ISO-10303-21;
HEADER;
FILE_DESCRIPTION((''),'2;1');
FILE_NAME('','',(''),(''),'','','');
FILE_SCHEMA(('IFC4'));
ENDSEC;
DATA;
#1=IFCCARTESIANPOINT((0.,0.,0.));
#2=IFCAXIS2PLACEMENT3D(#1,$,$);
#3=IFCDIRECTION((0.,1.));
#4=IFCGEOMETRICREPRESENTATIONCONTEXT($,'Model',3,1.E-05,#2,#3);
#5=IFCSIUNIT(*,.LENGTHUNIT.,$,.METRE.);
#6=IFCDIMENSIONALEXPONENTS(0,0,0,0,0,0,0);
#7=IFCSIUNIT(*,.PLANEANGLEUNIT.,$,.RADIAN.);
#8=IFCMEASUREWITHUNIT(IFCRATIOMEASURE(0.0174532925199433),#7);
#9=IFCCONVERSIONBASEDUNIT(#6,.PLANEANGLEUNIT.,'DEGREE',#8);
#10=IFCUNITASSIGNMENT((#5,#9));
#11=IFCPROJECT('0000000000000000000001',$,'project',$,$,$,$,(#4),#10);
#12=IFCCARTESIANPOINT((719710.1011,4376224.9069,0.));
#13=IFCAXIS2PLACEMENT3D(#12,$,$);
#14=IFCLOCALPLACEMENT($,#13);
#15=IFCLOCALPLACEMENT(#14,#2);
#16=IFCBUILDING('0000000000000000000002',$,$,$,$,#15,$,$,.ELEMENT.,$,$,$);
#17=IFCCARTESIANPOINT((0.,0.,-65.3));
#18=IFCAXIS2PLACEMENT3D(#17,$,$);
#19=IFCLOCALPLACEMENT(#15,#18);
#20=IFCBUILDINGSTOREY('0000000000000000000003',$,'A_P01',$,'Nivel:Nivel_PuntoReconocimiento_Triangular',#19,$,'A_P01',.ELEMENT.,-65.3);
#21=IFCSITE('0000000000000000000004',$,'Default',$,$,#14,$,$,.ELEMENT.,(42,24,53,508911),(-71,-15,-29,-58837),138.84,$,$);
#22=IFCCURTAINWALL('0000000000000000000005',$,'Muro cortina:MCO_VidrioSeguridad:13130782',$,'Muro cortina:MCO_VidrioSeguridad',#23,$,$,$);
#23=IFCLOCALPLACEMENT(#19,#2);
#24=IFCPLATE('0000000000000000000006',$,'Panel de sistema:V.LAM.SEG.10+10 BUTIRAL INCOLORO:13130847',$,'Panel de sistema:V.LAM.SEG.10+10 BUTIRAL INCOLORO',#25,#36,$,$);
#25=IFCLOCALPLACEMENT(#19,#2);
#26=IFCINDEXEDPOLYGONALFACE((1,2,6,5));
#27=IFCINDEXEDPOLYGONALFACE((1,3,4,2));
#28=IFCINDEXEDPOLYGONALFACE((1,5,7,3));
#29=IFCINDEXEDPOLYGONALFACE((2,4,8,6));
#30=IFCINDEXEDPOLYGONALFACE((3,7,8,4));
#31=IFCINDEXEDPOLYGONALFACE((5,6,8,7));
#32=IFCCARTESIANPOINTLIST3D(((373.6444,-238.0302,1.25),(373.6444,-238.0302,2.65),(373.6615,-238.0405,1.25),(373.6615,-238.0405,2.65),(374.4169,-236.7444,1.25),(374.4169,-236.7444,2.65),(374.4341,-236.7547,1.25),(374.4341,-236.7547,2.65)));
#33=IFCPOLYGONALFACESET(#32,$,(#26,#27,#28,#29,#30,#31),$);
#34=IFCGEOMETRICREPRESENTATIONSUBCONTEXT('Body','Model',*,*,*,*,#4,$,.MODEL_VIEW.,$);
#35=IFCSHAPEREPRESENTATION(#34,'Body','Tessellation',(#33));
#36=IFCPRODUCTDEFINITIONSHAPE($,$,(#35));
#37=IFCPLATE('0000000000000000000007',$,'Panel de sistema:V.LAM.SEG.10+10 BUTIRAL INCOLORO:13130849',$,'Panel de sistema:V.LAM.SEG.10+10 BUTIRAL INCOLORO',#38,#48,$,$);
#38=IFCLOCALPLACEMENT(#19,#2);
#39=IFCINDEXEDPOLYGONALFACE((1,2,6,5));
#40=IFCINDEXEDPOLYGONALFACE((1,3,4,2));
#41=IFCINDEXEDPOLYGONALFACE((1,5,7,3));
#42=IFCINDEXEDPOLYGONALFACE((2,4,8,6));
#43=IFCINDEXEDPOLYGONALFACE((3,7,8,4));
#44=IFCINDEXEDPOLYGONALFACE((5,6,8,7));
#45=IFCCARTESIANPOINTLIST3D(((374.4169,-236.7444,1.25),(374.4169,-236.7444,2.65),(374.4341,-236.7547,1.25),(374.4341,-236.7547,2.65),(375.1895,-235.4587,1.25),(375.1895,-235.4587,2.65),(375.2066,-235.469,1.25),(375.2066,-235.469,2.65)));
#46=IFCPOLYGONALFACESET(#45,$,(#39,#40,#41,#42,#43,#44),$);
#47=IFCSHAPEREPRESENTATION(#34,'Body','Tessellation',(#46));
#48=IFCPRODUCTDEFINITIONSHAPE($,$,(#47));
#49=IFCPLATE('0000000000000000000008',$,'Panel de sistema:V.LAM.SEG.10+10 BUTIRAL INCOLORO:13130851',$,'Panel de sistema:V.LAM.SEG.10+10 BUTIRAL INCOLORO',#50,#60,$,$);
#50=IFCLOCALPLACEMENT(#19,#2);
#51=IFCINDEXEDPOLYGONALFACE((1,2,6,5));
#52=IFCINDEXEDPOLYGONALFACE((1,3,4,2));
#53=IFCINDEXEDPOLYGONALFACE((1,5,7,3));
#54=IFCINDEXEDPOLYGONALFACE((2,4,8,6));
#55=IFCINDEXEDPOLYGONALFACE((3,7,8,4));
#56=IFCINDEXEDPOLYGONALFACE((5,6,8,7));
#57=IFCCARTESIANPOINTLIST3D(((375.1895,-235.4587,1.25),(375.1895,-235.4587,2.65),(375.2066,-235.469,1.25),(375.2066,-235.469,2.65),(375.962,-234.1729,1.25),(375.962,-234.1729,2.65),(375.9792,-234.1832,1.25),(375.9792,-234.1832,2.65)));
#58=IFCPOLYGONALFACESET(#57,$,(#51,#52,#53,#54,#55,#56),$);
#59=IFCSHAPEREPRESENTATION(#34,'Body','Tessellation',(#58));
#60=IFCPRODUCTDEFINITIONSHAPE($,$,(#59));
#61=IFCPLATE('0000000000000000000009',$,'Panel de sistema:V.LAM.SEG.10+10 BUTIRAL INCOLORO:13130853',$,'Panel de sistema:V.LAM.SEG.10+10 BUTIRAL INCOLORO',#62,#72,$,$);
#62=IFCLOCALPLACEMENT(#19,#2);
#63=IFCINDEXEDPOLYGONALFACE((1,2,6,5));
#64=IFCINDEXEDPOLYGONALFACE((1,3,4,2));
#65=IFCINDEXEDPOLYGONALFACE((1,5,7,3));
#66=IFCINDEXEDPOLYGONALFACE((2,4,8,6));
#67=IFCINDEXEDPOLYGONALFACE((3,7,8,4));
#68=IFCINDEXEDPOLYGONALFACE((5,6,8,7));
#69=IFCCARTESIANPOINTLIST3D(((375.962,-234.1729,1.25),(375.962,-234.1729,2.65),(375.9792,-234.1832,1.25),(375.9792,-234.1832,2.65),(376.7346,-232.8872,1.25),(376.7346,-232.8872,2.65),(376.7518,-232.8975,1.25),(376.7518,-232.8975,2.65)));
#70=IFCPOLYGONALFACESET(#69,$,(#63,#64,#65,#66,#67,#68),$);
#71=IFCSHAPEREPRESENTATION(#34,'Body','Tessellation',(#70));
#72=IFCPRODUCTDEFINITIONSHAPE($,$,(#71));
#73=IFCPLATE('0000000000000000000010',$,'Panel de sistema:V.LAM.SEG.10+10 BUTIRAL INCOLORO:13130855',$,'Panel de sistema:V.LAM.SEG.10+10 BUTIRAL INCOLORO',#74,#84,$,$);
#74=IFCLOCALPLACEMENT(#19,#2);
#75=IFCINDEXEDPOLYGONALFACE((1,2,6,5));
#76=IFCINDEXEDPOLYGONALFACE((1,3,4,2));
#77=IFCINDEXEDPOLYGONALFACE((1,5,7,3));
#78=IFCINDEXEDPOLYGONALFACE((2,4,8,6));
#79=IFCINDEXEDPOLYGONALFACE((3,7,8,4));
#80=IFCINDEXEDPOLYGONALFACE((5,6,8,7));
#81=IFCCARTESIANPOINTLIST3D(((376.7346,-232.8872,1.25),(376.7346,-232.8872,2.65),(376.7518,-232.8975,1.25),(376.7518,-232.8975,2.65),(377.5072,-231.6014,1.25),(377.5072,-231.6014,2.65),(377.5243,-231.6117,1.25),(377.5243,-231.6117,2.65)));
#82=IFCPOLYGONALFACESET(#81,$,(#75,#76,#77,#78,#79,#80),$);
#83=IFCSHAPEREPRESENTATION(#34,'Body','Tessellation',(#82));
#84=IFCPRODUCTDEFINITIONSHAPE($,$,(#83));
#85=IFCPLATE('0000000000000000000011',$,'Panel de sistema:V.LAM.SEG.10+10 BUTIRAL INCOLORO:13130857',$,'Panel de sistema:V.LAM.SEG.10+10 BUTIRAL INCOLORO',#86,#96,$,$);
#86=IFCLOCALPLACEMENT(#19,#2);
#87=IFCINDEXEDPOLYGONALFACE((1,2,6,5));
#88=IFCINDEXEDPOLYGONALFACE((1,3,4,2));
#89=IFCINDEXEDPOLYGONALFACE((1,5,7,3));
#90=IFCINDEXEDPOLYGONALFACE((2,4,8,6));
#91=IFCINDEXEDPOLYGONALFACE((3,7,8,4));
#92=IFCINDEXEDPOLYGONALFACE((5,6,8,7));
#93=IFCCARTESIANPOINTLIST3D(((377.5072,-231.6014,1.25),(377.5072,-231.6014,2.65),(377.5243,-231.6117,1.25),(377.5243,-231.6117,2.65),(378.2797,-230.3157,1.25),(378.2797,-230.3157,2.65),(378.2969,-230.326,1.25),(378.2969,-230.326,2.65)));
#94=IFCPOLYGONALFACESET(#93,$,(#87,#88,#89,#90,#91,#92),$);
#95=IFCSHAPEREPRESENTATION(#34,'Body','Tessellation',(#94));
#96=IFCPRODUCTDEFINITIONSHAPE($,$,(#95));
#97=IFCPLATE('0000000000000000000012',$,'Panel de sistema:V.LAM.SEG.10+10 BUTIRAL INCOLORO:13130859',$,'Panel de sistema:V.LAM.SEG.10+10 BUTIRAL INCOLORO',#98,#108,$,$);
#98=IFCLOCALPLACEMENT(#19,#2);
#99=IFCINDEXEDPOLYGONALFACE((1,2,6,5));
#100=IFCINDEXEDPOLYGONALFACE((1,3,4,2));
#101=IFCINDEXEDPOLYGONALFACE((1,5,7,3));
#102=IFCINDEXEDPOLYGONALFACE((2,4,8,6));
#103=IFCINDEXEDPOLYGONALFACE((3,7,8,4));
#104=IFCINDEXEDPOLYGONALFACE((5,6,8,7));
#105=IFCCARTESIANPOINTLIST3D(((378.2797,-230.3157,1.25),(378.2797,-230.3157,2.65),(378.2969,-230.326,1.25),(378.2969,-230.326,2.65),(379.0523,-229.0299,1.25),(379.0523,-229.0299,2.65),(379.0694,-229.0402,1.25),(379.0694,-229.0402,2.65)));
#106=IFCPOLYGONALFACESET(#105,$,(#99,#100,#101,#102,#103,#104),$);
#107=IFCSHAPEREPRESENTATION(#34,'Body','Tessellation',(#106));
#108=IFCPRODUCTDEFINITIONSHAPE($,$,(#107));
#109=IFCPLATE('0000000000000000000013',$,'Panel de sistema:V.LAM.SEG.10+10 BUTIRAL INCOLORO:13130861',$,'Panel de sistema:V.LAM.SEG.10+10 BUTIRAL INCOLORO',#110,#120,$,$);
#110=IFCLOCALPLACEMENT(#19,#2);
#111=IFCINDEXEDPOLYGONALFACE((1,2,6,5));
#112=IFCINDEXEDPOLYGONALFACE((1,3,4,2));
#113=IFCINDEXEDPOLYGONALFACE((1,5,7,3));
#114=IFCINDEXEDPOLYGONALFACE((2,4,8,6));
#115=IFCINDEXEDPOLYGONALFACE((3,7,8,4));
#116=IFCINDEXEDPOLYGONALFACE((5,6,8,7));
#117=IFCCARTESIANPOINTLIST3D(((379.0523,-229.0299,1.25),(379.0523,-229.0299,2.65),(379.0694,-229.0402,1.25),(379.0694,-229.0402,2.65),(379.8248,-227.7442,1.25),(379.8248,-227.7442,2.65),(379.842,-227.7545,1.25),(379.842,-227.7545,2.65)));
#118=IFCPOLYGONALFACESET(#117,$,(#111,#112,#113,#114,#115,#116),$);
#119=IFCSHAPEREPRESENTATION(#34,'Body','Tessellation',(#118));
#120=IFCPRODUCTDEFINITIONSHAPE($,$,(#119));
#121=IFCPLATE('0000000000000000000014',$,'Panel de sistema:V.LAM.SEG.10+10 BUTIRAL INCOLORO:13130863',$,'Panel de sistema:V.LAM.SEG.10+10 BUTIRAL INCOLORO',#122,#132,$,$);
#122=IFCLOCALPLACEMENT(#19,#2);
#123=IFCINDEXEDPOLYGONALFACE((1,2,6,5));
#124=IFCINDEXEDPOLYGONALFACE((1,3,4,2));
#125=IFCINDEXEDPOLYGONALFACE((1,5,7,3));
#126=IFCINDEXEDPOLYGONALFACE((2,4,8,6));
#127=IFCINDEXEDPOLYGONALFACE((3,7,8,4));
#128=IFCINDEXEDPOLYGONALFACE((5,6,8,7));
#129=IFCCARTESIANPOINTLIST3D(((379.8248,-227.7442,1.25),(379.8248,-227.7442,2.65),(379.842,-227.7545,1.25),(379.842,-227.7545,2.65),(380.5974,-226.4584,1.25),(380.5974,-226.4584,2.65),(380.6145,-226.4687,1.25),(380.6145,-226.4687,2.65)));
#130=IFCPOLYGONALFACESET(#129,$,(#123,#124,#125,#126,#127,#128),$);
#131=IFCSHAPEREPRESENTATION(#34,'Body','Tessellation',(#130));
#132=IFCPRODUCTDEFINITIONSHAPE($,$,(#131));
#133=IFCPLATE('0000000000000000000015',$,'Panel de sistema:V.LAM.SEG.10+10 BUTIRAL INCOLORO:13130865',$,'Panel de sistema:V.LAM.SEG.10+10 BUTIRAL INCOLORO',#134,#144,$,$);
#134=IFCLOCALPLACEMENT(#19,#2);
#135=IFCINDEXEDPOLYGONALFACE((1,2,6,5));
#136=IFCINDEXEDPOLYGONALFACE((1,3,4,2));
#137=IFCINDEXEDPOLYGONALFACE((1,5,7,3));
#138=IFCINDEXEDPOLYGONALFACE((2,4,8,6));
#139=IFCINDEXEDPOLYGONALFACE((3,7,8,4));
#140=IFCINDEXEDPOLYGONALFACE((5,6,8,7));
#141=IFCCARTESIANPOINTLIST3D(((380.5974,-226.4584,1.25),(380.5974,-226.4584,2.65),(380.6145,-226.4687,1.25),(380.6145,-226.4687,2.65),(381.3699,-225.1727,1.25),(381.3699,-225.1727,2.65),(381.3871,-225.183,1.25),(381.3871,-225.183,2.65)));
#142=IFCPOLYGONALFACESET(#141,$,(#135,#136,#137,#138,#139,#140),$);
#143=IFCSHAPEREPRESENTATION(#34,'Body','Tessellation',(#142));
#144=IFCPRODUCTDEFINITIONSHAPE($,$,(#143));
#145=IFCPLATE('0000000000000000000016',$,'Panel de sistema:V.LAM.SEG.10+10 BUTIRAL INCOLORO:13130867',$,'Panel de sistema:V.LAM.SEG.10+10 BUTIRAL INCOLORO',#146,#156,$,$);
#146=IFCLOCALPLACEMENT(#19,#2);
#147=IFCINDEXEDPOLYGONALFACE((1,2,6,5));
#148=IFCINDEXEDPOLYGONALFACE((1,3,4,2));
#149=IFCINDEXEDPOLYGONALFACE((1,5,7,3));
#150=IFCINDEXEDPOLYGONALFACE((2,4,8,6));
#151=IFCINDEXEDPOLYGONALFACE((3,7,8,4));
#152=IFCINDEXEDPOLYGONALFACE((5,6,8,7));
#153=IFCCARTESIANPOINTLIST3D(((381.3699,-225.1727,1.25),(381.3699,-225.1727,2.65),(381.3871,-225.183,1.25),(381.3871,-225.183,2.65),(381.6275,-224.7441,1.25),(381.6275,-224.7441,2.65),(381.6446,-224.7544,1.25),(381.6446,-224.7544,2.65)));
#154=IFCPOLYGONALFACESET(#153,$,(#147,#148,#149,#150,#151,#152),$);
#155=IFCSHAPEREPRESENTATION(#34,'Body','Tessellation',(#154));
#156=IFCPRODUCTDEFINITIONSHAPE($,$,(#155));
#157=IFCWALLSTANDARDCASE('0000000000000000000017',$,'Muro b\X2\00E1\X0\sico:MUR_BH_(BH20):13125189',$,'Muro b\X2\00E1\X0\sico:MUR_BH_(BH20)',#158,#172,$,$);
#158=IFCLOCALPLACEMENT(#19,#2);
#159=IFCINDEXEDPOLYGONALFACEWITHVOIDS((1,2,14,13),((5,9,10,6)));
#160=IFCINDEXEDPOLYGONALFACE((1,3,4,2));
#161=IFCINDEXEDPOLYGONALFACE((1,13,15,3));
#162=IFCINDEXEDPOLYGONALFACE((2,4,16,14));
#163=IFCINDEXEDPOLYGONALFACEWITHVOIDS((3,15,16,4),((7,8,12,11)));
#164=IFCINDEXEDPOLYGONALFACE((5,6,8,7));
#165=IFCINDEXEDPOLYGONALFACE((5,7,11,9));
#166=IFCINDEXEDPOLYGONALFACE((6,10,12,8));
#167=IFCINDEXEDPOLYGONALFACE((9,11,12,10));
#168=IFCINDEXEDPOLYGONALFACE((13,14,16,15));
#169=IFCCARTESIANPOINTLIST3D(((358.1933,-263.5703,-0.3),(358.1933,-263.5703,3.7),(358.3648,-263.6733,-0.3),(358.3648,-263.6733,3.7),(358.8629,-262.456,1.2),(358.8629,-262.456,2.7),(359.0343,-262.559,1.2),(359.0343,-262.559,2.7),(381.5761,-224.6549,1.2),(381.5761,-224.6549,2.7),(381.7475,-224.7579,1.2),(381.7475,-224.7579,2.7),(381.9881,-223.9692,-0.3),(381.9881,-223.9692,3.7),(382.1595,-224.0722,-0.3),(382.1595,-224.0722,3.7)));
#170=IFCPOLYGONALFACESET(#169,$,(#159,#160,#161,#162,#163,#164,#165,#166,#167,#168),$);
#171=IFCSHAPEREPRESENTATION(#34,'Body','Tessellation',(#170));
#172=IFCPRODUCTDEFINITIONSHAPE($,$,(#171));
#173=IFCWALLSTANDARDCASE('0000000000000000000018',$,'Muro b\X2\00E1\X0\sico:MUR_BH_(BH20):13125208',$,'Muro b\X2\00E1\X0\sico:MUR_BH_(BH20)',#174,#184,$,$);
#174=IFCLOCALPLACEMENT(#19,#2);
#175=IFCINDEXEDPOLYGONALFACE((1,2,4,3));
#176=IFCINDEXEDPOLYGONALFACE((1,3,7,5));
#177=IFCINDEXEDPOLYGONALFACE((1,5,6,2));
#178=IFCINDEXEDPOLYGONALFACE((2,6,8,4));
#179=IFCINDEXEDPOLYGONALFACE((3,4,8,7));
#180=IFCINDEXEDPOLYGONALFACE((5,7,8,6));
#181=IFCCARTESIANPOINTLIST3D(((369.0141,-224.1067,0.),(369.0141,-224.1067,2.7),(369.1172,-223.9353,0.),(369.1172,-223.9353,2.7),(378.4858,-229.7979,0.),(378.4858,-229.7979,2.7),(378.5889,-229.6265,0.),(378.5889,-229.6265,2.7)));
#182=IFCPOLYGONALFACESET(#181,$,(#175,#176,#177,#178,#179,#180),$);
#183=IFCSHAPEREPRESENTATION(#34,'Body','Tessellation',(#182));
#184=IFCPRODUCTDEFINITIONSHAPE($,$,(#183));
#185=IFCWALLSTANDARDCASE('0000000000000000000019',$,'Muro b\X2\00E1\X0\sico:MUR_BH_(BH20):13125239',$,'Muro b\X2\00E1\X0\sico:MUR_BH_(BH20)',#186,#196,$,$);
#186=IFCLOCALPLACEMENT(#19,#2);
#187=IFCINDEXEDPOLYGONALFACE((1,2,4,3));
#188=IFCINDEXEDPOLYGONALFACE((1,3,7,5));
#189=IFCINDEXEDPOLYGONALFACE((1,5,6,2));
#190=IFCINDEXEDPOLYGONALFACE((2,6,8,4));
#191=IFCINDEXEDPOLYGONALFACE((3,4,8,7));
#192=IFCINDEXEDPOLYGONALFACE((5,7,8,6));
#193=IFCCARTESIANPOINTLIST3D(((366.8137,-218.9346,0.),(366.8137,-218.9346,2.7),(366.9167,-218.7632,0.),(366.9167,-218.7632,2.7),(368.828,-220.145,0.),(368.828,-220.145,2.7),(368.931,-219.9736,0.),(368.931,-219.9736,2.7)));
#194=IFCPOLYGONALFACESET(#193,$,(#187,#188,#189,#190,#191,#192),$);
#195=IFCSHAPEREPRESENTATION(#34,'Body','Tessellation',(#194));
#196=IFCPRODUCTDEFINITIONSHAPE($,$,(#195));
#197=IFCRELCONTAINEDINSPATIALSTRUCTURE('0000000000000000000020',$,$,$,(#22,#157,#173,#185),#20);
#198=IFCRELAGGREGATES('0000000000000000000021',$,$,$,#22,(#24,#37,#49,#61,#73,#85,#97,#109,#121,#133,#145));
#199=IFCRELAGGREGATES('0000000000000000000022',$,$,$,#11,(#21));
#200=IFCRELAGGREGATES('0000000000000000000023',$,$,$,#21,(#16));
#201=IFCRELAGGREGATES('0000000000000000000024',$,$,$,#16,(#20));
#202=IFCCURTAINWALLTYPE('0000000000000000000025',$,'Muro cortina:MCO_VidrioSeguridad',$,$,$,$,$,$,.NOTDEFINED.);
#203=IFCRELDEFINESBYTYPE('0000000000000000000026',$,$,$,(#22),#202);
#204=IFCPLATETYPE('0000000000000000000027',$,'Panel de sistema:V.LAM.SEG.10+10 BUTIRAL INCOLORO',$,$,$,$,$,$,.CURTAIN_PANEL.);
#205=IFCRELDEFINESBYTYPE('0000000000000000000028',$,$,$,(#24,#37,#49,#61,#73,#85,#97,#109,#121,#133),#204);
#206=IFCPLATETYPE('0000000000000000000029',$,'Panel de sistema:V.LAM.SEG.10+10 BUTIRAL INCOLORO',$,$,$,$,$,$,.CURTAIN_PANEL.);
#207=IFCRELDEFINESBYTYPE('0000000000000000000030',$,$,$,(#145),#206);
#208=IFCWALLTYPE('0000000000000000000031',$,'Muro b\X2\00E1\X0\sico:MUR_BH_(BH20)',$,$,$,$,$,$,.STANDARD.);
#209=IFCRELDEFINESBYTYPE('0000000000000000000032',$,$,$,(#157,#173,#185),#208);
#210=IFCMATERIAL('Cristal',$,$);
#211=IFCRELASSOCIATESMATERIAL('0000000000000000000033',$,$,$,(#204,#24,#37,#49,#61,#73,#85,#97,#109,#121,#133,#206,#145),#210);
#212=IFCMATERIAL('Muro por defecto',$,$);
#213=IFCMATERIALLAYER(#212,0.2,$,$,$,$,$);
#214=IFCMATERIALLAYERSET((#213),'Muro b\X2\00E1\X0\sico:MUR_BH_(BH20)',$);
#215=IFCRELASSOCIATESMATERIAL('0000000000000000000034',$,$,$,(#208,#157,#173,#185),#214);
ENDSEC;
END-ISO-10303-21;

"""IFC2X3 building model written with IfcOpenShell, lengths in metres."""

from ifc_helpers import new_model, entity, si_unit, converted_unit, direction, frame, frame_2d, origin, origin_2d_with_axis, place, context, subcontext, project, spatial, rectangle, extrude, source, transform, mapped, material, layer, layer_set, layer_usage, type_object, type_shapes, element, aggregate, save


model = new_model("IFC2X3")

# Units and contexts
model_context = context("Model", 3, precision=1e-05, world=origin(), true_north=direction((0.0, 1.0)))
body_context = subcontext(model_context, "Body", "Model", "MODEL_VIEW")
ifc_project = project(units=[si_unit("LENGTHUNIT", "METRE"), converted_unit("PLANEANGLEUNIT", "DEGREE", entity("IfcRatioMeasure", 0.0174532925199433), si_unit("PLANEANGLEUNIT", "RADIAN"), dimensions=[0, 0, 0, 0, 0, 0, 0])], contexts=[model_context])

# Site, building, storey
site_placement = place(None, frame((719710.1011, 4376224.9069, 0.0)))
site = spatial("IfcSite", under=ifc_project, at=site_placement, Name="Default", CompositionType="ELEMENT", RefLatitude=(42, 24, 53, 508911), RefLongitude=(-71, -15, -29, -58837), RefElevation=138.84)
building_placement = place(site_placement, origin())
building = spatial("IfcBuilding", under=site, at=building_placement, CompositionType="ELEMENT")
storey_placement = place(building_placement, frame((0.0, 0.0, -65.3)))
storey = spatial("IfcBuildingStorey", under=building, at=storey_placement, Name="A_P01", ObjectType="Nivel:Nivel_PuntoReconocimiento_Triangular", LongName="A_P01", CompositionType="ELEMENT", Elevation=-65.3)

# Curtain wall, plates
curtain_wall_type = type_object("IfcCurtainWallType", Name="Muro cortina:MCO_VidrioSeguridad", PredefinedType="NOTDEFINED")
curtain_wall_placement = place(storey_placement, frame((0.0, 0.0, 65.3)))
curtain_wall = element("IfcCurtainWall", 1, at=curtain_wall_placement, inside=storey, type_object=curtain_wall_type, Name="Muro cortina:MCO_VidrioSeguridad:13130782", ObjectType="Muro cortina:MCO_VidrioSeguridad")
ifc_material_1 = material(Name="Cristal")
plate_type_1 = type_object("IfcPlateType", Name="Panel de sistema:V.LAM.SEG.10+10 BUTIRAL INCOLORO", PredefinedType="CURTAIN_PANEL", material=ifc_material_1)
shared_shape_1 = source(origin(), body_context, "Body", "SweptSolid", [
    extrude(rectangle(XDim=0.02, YDim=1.5, at=origin_2d_with_axis()), frame((0.0, 0.0, 0.0), z_axis=(0.0, 0.0, 1.0), x_axis=(0.0, 1.0, 0.0)), (0.0, 0.0, 1.0), 1.4),
])
type_shapes(plate_type_1, [shared_shape_1])
plate_1_placement = place(curtain_wall_placement, frame((374.0392, -237.3925, -64.05), z_axis=(0.0, 0.0, 1.0), x_axis=(0.515038, 0.857167, 0.0)))
plate_1 = element("IfcPlate", 2, at=plate_1_placement, type_object=plate_type_1, material=ifc_material_1, Name="Panel de sistema:V.LAM.SEG.10+10 BUTIRAL INCOLORO:13130847", ObjectType="Panel de sistema:V.LAM.SEG.10+10 BUTIRAL INCOLORO", context=body_context, shape_type="MappedRepresentation", body=[
    mapped(shared_shape_1, transform((0.0, 0.0, 0.0), scale=1.0)),
])
plate_2_placement = place(curtain_wall_placement, frame((374.8118, -236.1067, -64.05), z_axis=(0.0, 0.0, 1.0), x_axis=(0.515038, 0.857167, 0.0)))
plate_2 = element("IfcPlate", 3, at=plate_2_placement, type_object=plate_type_1, material=ifc_material_1, Name="Panel de sistema:V.LAM.SEG.10+10 BUTIRAL INCOLORO:13130849", ObjectType="Panel de sistema:V.LAM.SEG.10+10 BUTIRAL INCOLORO", context=body_context, shape_type="MappedRepresentation", body=[
    mapped(shared_shape_1, transform((0.0, 0.0, 0.0), scale=1.0)),
])
plate_3_placement = place(curtain_wall_placement, frame((375.5843, -234.821, -64.05), z_axis=(0.0, 0.0, 1.0), x_axis=(0.515038, 0.857167, 0.0)))
plate_3 = element("IfcPlate", 4, at=plate_3_placement, type_object=plate_type_1, material=ifc_material_1, Name="Panel de sistema:V.LAM.SEG.10+10 BUTIRAL INCOLORO:13130851", ObjectType="Panel de sistema:V.LAM.SEG.10+10 BUTIRAL INCOLORO", context=body_context, shape_type="MappedRepresentation", body=[
    mapped(shared_shape_1, transform((0.0, 0.0, 0.0), scale=1.0)),
])
plate_4_placement = place(curtain_wall_placement, frame((376.3569, -233.5352, -64.05), z_axis=(0.0, 0.0, 1.0), x_axis=(0.515038, 0.857167, 0.0)))
plate_4 = element("IfcPlate", 5, at=plate_4_placement, type_object=plate_type_1, material=ifc_material_1, Name="Panel de sistema:V.LAM.SEG.10+10 BUTIRAL INCOLORO:13130853", ObjectType="Panel de sistema:V.LAM.SEG.10+10 BUTIRAL INCOLORO", context=body_context, shape_type="MappedRepresentation", body=[
    mapped(shared_shape_1, transform((0.0, 0.0, 0.0), scale=1.0)),
])
plate_5_placement = place(curtain_wall_placement, frame((377.1295, -232.2495, -64.05), z_axis=(0.0, 0.0, 1.0), x_axis=(0.515038, 0.857167, 0.0)))
plate_5 = element("IfcPlate", 6, at=plate_5_placement, type_object=plate_type_1, material=ifc_material_1, Name="Panel de sistema:V.LAM.SEG.10+10 BUTIRAL INCOLORO:13130855", ObjectType="Panel de sistema:V.LAM.SEG.10+10 BUTIRAL INCOLORO", context=body_context, shape_type="MappedRepresentation", body=[
    mapped(shared_shape_1, transform((0.0, 0.0, 0.0), scale=1.0)),
])
plate_6_placement = place(curtain_wall_placement, frame((377.902, -230.9637, -64.05), z_axis=(0.0, 0.0, 1.0), x_axis=(0.515038, 0.857167, 0.0)))
plate_6 = element("IfcPlate", 7, at=plate_6_placement, type_object=plate_type_1, material=ifc_material_1, Name="Panel de sistema:V.LAM.SEG.10+10 BUTIRAL INCOLORO:13130857", ObjectType="Panel de sistema:V.LAM.SEG.10+10 BUTIRAL INCOLORO", context=body_context, shape_type="MappedRepresentation", body=[
    mapped(shared_shape_1, transform((0.0, 0.0, 0.0), scale=1.0)),
])
plate_7_placement = place(curtain_wall_placement, frame((378.6746, -229.678, -64.05), z_axis=(0.0, 0.0, 1.0), x_axis=(0.515038, 0.857167, 0.0)))
plate_7 = element("IfcPlate", 8, at=plate_7_placement, type_object=plate_type_1, material=ifc_material_1, Name="Panel de sistema:V.LAM.SEG.10+10 BUTIRAL INCOLORO:13130859", ObjectType="Panel de sistema:V.LAM.SEG.10+10 BUTIRAL INCOLORO", context=body_context, shape_type="MappedRepresentation", body=[
    mapped(shared_shape_1, transform((0.0, 0.0, 0.0), scale=1.0)),
])
plate_8_placement = place(curtain_wall_placement, frame((379.4471, -228.3922, -64.05), z_axis=(0.0, 0.0, 1.0), x_axis=(0.515038, 0.857167, 0.0)))
plate_8 = element("IfcPlate", 9, at=plate_8_placement, type_object=plate_type_1, material=ifc_material_1, Name="Panel de sistema:V.LAM.SEG.10+10 BUTIRAL INCOLORO:13130861", ObjectType="Panel de sistema:V.LAM.SEG.10+10 BUTIRAL INCOLORO", context=body_context, shape_type="MappedRepresentation", body=[
    mapped(shared_shape_1, transform((0.0, 0.0, 0.0), scale=1.0)),
])
plate_9_placement = place(curtain_wall_placement, frame((380.2197, -227.1065, -64.05), z_axis=(0.0, 0.0, 1.0), x_axis=(0.515038, 0.857167, 0.0)))
plate_9 = element("IfcPlate", 10, at=plate_9_placement, type_object=plate_type_1, material=ifc_material_1, Name="Panel de sistema:V.LAM.SEG.10+10 BUTIRAL INCOLORO:13130863", ObjectType="Panel de sistema:V.LAM.SEG.10+10 BUTIRAL INCOLORO", context=body_context, shape_type="MappedRepresentation", body=[
    mapped(shared_shape_1, transform((0.0, 0.0, 0.0), scale=1.0)),
])
plate_10_placement = place(curtain_wall_placement, frame((380.9922, -225.8207, -64.05), z_axis=(0.0, 0.0, 1.0), x_axis=(0.515038, 0.857167, 0.0)))
plate_10 = element("IfcPlate", 11, at=plate_10_placement, type_object=plate_type_1, material=ifc_material_1, Name="Panel de sistema:V.LAM.SEG.10+10 BUTIRAL INCOLORO:13130865", ObjectType="Panel de sistema:V.LAM.SEG.10+10 BUTIRAL INCOLORO", context=body_context, shape_type="MappedRepresentation", body=[
    mapped(shared_shape_1, transform((0.0, 0.0, 0.0), scale=1.0)),
])
plate_type_2 = type_object("IfcPlateType", Name="Panel de sistema:V.LAM.SEG.10+10 BUTIRAL INCOLORO", PredefinedType="CURTAIN_PANEL", material=ifc_material_1)
shared_shape_2 = source(origin(), body_context, "Body", "SweptSolid", [
    extrude(rectangle(XDim=0.02, YDim=0.5, at=origin_2d_with_axis()), frame((0.0, 0.0, 0.0), z_axis=(0.0, 0.0, 1.0), x_axis=(0.0, 1.0, 0.0)), (0.0, 0.0, 1.0), 1.4),
])
type_shapes(plate_type_2, [shared_shape_2])
plate_11_placement = place(curtain_wall_placement, frame((381.5073, -224.9635, -64.05), z_axis=(0.0, 0.0, 1.0), x_axis=(0.515038, 0.857167, 0.0)))
plate_11 = element("IfcPlate", 12, at=plate_11_placement, type_object=plate_type_2, material=ifc_material_1, Name="Panel de sistema:V.LAM.SEG.10+10 BUTIRAL INCOLORO:13130867", ObjectType="Panel de sistema:V.LAM.SEG.10+10 BUTIRAL INCOLORO", context=body_context, shape_type="MappedRepresentation", body=[
    mapped(shared_shape_2, transform((0.0, 0.0, 0.0), scale=1.0)),
])
aggregate(curtain_wall, [plate_1, plate_2, plate_3, plate_4, plate_5, plate_6, plate_7, plate_8, plate_9, plate_10, plate_11])

# Wall, opening
ifc_material_2 = material(Name="Muro por defecto")
ifc_layer = layer(ifc_material_2, 0.2)
ifc_layer_set = layer_set([ifc_layer], Name="Muro básico:MUR_BH_(BH20)")
ifc_layer_usage_1 = layer_usage(ifc_layer_set, "AXIS2", "NEGATIVE", 0.1)
wall_type = type_object("IfcWallType", Name="Muro básico:MUR_BH_(BH20)", PredefinedType="STANDARD", material=ifc_layer_set)
wall_1_placement = place(storey_placement, frame((382.0738, -224.0207, -0.3), z_axis=(0.0, 0.0, 1.0), x_axis=(-0.515038, -0.857167, 0.0)))
wall_1 = element("IfcWallStandardCase", 13, at=wall_1_placement, inside=storey, type_object=wall_type, material=ifc_layer_usage_1, Name="Muro básico:MUR_BH_(BH20):13125189", ObjectType="Muro básico:MUR_BH_(BH20)", context=body_context, shape_type="SweptSolid", body=[
    extrude(rectangle(XDim=46.2, YDim=0.2, at=frame_2d((23.1, 0.0), x_axis=(-1.0, 0.0))), origin(), (0.0, 0.0, 1.0), 4.0),
])
opening_placement = place(wall_1_placement, origin())
element("IfcOpeningElement", 14, at=opening_placement, cuts=wall_1, ObjectType="Opening", context=body_context, shape_type="SweptSolid", body=[
    extrude(rectangle(XDim=1.5, YDim=44.1, at=frame_2d((0.0, 0.0), x_axis=(0.0, 1.0))), frame((22.85, -0.2524, 2.25), z_axis=(0.0, 1.0, 0.0), x_axis=(-1.0, 0.0, 0.0)), (0.0, 0.0, 1.0), 0.5048),
])

# Walls
ifc_layer_usage_2 = layer_usage(ifc_layer_set, "AXIS2", "NEGATIVE", 0.1)
wall_2_placement = place(storey_placement, frame((369.0657, -224.021, 0.0), z_axis=(0.0, 0.0, 1.0), x_axis=(0.857167, -0.515038, 0.0)))
element("IfcWallStandardCase", 15, at=wall_2_placement, inside=storey, type_object=wall_type, material=ifc_layer_usage_2, Name="Muro básico:MUR_BH_(BH20):13125208", ObjectType="Muro básico:MUR_BH_(BH20)", context=body_context, shape_type="SweptSolid", body=[
    extrude(rectangle(XDim=11.05, YDim=0.2, at=frame_2d((5.525, 0.0), x_axis=(-1.0, 0.0))), origin(), (0.0, 0.0, 1.0), 2.7),
])
ifc_layer_usage_3 = layer_usage(ifc_layer_set, "AXIS2", "NEGATIVE", 0.1)
wall_3_placement = place(storey_placement, frame((366.8652, -218.8489, 0.0), z_axis=(0.0, 0.0, 1.0), x_axis=(0.857167, -0.515038, 0.0)))
element("IfcWallStandardCase", 16, at=wall_3_placement, inside=storey, type_object=wall_type, material=ifc_layer_usage_3, Name="Muro básico:MUR_BH_(BH20):13125239", ObjectType="Muro básico:MUR_BH_(BH20)", context=body_context, shape_type="SweptSolid", body=[
    extrude(rectangle(XDim=2.35, YDim=0.2, at=frame_2d((1.175, 0.0), x_axis=(-1.0, 0.0))), origin(), (0.0, 0.0, 1.0), 2.7),
])

save(model, "model.ifc")
